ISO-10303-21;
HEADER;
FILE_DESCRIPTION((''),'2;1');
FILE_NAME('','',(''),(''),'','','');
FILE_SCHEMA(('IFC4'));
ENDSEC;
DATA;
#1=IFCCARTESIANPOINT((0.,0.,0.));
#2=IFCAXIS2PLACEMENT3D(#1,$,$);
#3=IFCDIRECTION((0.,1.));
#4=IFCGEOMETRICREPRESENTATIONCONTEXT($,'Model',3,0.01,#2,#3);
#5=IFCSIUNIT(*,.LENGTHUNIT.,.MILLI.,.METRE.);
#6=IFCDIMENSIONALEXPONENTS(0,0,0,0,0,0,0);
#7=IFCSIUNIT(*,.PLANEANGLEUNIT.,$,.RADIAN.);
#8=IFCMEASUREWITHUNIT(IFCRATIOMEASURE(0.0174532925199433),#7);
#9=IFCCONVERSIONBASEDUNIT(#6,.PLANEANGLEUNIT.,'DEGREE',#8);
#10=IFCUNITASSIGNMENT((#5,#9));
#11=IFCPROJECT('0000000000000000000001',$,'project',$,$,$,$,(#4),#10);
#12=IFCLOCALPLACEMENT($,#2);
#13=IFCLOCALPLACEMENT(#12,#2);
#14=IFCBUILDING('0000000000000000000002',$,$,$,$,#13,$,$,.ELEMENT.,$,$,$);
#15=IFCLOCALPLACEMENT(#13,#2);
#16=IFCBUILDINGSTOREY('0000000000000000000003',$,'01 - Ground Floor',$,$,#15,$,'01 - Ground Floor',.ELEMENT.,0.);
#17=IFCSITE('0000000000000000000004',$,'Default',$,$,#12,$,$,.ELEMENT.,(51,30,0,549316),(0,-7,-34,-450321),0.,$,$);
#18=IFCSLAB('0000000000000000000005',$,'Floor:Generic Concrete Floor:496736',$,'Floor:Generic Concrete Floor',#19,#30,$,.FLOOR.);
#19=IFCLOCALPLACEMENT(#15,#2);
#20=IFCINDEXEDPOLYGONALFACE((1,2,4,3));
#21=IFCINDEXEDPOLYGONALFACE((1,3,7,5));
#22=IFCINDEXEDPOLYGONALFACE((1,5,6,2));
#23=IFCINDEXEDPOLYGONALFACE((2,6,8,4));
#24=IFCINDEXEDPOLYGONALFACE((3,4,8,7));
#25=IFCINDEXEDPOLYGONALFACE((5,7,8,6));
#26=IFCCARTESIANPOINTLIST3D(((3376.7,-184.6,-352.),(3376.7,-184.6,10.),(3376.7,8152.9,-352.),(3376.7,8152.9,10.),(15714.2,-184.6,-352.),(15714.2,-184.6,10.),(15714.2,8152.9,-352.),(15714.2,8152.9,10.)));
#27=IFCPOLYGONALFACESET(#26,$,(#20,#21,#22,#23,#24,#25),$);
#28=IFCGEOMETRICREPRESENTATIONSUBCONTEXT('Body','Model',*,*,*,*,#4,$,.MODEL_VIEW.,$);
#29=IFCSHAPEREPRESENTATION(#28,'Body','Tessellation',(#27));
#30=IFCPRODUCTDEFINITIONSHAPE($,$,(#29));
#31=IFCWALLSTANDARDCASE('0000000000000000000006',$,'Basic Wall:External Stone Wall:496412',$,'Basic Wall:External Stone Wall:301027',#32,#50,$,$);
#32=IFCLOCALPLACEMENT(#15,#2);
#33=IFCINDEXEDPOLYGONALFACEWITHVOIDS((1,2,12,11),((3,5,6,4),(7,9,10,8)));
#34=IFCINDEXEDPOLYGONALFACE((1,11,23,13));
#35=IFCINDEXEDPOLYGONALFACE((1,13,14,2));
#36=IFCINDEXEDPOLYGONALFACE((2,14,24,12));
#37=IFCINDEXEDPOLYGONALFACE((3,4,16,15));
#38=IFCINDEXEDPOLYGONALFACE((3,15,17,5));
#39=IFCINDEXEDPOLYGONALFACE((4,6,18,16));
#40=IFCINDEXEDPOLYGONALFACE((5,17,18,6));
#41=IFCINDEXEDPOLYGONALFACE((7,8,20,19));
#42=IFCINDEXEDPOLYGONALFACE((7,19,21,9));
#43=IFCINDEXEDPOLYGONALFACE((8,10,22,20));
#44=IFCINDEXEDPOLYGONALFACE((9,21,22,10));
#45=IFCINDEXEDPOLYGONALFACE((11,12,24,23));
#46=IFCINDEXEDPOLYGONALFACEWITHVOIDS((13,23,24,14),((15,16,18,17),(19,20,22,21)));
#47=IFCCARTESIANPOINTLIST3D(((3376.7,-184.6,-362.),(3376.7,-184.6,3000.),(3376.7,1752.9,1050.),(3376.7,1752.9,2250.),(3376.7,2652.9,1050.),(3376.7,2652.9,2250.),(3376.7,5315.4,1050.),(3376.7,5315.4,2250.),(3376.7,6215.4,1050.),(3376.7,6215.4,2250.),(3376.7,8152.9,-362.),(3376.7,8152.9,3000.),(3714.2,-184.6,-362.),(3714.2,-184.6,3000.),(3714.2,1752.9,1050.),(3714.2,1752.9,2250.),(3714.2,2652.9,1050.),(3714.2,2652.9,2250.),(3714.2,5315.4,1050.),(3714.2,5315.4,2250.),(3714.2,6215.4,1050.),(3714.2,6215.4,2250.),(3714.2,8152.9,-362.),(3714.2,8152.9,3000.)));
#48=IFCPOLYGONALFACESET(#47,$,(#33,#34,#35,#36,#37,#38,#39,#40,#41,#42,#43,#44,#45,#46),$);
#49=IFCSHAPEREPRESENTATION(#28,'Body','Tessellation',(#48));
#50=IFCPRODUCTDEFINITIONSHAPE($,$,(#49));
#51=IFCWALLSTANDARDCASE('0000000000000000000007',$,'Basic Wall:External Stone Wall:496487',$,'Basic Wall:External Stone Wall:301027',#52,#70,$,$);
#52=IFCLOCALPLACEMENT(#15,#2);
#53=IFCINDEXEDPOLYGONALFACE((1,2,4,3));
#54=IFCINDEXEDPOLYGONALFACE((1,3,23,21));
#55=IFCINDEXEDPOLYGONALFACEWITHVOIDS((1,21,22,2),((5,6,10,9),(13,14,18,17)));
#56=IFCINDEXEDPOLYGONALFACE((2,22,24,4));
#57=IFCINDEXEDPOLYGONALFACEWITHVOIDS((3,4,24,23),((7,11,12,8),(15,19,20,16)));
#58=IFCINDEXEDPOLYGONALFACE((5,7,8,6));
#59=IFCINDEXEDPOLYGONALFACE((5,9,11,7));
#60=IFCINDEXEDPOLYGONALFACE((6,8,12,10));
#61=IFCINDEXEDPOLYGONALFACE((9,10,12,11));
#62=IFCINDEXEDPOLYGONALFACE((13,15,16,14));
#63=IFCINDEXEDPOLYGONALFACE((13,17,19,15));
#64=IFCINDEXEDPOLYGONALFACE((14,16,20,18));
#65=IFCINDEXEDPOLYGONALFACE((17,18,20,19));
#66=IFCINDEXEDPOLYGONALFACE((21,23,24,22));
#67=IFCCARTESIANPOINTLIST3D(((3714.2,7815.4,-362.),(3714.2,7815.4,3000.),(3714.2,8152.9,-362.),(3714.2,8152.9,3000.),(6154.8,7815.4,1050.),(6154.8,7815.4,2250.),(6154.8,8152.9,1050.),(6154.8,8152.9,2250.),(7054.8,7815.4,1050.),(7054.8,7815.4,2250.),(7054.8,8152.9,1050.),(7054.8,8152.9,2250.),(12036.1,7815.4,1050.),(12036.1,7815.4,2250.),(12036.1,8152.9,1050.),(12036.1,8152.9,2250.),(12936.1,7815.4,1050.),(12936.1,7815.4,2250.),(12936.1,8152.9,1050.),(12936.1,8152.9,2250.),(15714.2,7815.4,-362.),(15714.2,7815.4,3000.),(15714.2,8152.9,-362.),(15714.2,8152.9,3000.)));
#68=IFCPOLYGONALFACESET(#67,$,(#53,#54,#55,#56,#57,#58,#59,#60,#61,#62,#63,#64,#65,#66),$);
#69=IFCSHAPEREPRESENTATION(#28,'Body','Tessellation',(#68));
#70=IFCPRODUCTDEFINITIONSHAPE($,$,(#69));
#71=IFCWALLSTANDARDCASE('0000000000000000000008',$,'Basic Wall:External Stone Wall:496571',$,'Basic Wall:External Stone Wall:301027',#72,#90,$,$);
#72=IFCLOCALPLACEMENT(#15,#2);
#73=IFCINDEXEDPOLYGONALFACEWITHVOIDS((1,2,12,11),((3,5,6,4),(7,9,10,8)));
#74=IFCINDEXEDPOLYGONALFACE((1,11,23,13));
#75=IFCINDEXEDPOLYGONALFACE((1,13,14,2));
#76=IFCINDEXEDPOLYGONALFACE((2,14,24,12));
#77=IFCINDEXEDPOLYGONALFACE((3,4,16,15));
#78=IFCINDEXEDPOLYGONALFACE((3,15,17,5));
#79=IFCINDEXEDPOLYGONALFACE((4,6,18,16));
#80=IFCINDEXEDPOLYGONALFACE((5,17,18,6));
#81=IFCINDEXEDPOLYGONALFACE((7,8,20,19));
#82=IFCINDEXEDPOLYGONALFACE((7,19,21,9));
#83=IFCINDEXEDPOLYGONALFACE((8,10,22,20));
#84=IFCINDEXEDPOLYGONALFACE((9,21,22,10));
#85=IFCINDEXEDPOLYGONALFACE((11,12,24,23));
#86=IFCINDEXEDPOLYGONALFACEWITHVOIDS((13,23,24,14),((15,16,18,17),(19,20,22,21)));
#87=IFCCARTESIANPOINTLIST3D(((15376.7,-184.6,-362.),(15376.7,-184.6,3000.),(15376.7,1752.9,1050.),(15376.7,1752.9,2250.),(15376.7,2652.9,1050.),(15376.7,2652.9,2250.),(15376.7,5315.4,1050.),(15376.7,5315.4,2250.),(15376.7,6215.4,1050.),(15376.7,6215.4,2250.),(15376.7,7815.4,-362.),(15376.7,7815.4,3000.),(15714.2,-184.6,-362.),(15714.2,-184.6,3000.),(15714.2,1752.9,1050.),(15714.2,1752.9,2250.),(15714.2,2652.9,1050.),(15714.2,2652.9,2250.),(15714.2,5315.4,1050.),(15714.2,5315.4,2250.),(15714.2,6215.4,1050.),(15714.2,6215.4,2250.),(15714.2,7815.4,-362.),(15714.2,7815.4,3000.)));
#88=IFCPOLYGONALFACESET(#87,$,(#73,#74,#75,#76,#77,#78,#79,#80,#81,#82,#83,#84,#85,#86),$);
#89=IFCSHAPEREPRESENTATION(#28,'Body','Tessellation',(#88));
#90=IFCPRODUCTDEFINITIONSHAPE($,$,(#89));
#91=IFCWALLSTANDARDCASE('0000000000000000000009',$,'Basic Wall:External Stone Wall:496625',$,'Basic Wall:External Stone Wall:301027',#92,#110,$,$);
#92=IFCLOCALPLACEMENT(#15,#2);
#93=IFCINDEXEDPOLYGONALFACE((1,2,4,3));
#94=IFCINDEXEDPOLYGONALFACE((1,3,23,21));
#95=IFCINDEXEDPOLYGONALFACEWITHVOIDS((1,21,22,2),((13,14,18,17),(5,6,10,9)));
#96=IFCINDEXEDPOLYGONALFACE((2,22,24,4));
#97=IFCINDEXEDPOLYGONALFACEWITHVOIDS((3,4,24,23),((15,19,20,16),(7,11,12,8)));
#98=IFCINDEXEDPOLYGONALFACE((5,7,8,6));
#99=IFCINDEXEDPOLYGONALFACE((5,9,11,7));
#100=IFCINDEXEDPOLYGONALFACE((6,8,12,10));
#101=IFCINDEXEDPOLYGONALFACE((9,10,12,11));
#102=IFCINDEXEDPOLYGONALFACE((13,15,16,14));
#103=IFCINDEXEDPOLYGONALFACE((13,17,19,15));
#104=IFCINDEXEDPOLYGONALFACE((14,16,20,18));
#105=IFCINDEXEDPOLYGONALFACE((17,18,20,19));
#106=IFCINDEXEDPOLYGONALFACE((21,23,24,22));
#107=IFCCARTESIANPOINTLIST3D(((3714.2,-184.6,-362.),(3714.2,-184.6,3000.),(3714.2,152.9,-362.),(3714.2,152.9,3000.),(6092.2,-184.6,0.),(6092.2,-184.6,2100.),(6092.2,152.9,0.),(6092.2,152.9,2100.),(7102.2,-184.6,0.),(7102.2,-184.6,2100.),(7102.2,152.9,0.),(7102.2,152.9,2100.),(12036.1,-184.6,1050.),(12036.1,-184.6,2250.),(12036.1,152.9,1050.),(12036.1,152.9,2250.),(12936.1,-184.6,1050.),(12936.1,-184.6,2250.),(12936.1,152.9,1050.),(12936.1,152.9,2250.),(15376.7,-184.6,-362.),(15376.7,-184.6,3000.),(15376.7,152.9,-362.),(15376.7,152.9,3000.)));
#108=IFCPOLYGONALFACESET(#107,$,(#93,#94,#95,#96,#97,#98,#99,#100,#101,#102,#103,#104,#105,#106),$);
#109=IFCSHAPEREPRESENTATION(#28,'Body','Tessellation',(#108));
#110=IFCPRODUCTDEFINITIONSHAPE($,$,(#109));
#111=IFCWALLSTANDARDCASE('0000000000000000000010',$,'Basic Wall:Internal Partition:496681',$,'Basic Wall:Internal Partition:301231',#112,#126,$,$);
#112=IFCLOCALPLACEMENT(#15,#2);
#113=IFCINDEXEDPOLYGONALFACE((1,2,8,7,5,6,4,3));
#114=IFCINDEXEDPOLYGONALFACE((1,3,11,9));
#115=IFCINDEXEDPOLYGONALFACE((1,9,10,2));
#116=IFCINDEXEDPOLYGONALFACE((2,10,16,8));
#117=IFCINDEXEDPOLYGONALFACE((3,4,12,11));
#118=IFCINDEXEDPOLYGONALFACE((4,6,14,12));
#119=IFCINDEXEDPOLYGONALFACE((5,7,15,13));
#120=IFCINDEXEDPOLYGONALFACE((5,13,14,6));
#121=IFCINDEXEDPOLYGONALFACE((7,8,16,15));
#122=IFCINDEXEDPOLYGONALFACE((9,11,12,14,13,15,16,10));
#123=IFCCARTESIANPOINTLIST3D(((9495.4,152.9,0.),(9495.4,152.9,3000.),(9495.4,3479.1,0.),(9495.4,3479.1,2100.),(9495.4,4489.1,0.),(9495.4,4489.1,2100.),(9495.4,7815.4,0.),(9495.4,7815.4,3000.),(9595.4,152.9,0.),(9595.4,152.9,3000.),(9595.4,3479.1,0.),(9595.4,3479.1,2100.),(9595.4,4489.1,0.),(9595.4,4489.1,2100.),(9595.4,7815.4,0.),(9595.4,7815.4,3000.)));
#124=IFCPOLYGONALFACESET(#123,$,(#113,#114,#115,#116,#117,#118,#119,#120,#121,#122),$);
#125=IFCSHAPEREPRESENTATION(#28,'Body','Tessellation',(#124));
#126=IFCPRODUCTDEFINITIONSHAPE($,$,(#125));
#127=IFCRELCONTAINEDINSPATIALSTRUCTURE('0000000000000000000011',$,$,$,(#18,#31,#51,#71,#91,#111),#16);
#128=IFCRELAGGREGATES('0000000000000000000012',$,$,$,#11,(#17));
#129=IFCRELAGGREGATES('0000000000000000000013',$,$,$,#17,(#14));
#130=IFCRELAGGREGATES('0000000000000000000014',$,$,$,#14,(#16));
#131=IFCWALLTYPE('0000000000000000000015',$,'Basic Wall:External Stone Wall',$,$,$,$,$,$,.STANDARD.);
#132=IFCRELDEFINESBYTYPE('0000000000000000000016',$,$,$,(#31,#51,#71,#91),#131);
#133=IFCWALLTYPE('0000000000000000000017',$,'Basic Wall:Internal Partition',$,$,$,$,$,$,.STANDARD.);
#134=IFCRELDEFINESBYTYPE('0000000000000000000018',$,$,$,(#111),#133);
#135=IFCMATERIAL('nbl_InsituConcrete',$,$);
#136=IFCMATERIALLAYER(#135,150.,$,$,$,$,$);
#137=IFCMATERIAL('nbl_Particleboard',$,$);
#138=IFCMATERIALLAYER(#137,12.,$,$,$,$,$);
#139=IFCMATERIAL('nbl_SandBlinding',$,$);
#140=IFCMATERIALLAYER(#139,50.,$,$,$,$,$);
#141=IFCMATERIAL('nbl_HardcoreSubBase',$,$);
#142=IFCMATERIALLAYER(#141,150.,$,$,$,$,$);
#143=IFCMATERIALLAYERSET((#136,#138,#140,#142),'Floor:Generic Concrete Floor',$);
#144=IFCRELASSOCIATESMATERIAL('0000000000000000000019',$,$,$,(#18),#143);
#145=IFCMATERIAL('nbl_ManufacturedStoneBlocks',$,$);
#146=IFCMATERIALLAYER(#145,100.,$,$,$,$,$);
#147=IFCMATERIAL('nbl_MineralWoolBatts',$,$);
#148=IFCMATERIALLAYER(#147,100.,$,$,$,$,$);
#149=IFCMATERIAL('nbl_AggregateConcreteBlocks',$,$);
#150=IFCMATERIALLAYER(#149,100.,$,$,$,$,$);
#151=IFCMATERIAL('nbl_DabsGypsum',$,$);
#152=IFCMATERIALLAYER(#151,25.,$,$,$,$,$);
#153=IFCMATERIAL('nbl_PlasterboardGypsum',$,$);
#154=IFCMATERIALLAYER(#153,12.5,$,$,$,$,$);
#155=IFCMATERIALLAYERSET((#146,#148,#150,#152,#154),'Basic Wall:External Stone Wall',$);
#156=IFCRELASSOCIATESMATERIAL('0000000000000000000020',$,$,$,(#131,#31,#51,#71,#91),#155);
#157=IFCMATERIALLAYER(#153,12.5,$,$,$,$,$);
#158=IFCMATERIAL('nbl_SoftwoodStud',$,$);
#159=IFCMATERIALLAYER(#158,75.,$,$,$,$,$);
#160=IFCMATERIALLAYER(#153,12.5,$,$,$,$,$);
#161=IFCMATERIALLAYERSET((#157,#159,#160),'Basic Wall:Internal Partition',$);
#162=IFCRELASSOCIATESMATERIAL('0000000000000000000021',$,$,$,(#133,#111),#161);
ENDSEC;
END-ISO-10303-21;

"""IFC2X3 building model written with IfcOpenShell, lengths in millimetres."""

from ifc_helpers import new_model, entity, si_unit, converted_unit, direction, frame, frame_2d, origin, origin_2d_with_axis, place, context, subcontext, project, spatial, rectangle, extrude, material, layer, layer_set, layer_usage, type_object, element, save


model = new_model("IFC2X3")

# Units and contexts
model_context = context("Model", 3, precision=0.01, world=origin(), true_north=direction((0.0, 1.0)))
body_context = subcontext(model_context, "Body", "Model", "MODEL_VIEW")
ifc_project = project(units=[si_unit("LENGTHUNIT", "METRE", prefix="MILLI"), converted_unit("PLANEANGLEUNIT", "DEGREE", entity("IfcRatioMeasure", 0.0174532925199433), si_unit("PLANEANGLEUNIT", "RADIAN"), dimensions=[0, 0, 0, 0, 0, 0, 0])], contexts=[model_context])

# Site, building, storey
site_placement = place(None, origin())
site = spatial("IfcSite", under=ifc_project, at=site_placement, Name="Default", CompositionType="ELEMENT", RefLatitude=(51, 30, 0, 549316), RefLongitude=(0, -7, -34, -450321), RefElevation=0.0)
building_placement = place(site_placement, origin())
building = spatial("IfcBuilding", under=site, at=building_placement, CompositionType="ELEMENT")
storey_placement = place(building_placement, origin())
storey = spatial("IfcBuildingStorey", under=building, at=storey_placement, Name="01 - Ground Floor", LongName="01 - Ground Floor", CompositionType="ELEMENT", Elevation=0.0)

# Slab
ifc_material_1 = material(Name="nbl_InsituConcrete")
ifc_layer_1 = layer(ifc_material_1, 150.0)
ifc_material_2 = material(Name="nbl_Particleboard")
ifc_layer_2 = layer(ifc_material_2, 12.0)
ifc_material_3 = material(Name="nbl_SandBlinding")
ifc_layer_3 = layer(ifc_material_3, 50.0)
ifc_material_4 = material(Name="nbl_HardcoreSubBase")
ifc_layer_4 = layer(ifc_material_4, 150.0)
ifc_layer_set_1 = layer_set([ifc_layer_1, ifc_layer_2, ifc_layer_3, ifc_layer_4], Name="Floor:Generic Concrete Floor")
ifc_layer_usage_1 = layer_usage(ifc_layer_set_1, "AXIS3", "POSITIVE", 0.0)
slab_placement = place(storey_placement, origin())
element("IfcSlab", 1, at=slab_placement, inside=storey, material=ifc_layer_usage_1, Name="Floor:Generic Concrete Floor:496736", ObjectType="Floor:Generic Concrete Floor", PredefinedType="FLOOR", context=body_context, shape_type="SweptSolid", body=[
    extrude(rectangle(XDim=8337.5, YDim=12337.5, at=origin_2d_with_axis()), frame((9545.4, 3984.1, 10.0), z_axis=(0.0, 0.0, -1.0), x_axis=(0.0, 1.0, 0.0)), (0.0, 0.0, 1.0), 362.0),
])

# Walls, openings
ifc_material_5 = material(Name="nbl_ManufacturedStoneBlocks")
ifc_layer_5 = layer(ifc_material_5, 100.0)
ifc_material_6 = material(Name="nbl_MineralWoolBatts")
ifc_layer_6 = layer(ifc_material_6, 100.0)
ifc_material_7 = material(Name="nbl_AggregateConcreteBlocks")
ifc_layer_7 = layer(ifc_material_7, 100.0)
ifc_material_8 = material(Name="nbl_DabsGypsum")
ifc_layer_8 = layer(ifc_material_8, 25.0)
ifc_material_9 = material(Name="nbl_PlasterboardGypsum")
ifc_layer_9 = layer(ifc_material_9, 12.5)
ifc_layer_set_2 = layer_set([ifc_layer_5, ifc_layer_6, ifc_layer_7, ifc_layer_8, ifc_layer_9], Name="Basic Wall:External Stone Wall")
ifc_layer_usage_2 = layer_usage(ifc_layer_set_2, "AXIS2", "NEGATIVE", 168.8)
wall_type_1 = type_object("IfcWallType", Name="Basic Wall:External Stone Wall", PredefinedType="STANDARD", material=ifc_layer_set_2)
wall_1_placement = place(storey_placement, frame((3545.4, -184.6, -362.0), z_axis=(0.0, 0.0, 1.0), x_axis=(0.0, 1.0, 0.0)))
wall_1 = element("IfcWallStandardCase", 2, at=wall_1_placement, inside=storey, type_object=wall_type_1, material=ifc_layer_usage_2, Name="Basic Wall:External Stone Wall:496412", ObjectType="Basic Wall:External Stone Wall:301027", context=body_context, shape_type="SweptSolid", body=[
    extrude(rectangle(XDim=8337.5, YDim=337.5, at=frame_2d((4168.7, 0.0), x_axis=(-1.0, 0.0))), origin(), (0.0, 0.0, 1.0), 3362.0),
])
opening_1_placement = place(wall_1_placement, frame((5500.0, -168.8, 1412.0)))
element("IfcOpeningElement", 3, at=opening_1_placement, cuts=wall_1, ObjectType="Opening", context=body_context, shape_type="SweptSolid", body=[
    extrude(rectangle(XDim=1200.0, YDim=900.0, at=frame_2d((600.0, 450.0), x_axis=(-1.0, 0.0))), frame((0.0, 0.0, 0.0), z_axis=(0.0, 1.0, 0.0), x_axis=(0.0, 0.0, 1.0)), (0.0, 0.0, 1.0), 337.5),
])
opening_2_placement = place(wall_1_placement, frame((1937.5, -168.8, 1412.0)))
element("IfcOpeningElement", 4, at=opening_2_placement, cuts=wall_1, ObjectType="Opening", context=body_context, shape_type="SweptSolid", body=[
    extrude(rectangle(XDim=1200.0, YDim=900.0, at=frame_2d((600.0, 450.0), x_axis=(-1.0, 0.0))), frame((0.0, 0.0, 0.0), z_axis=(0.0, 1.0, 0.0), x_axis=(0.0, 0.0, 1.0)), (0.0, 0.0, 1.0), 337.5),
])
ifc_layer_usage_3 = layer_usage(ifc_layer_set_2, "AXIS2", "NEGATIVE", 168.8)
wall_2_placement = place(storey_placement, frame((3714.2, 7984.1, -362.0)))
wall_2 = element("IfcWallStandardCase", 5, at=wall_2_placement, inside=storey, type_object=wall_type_1, material=ifc_layer_usage_3, Name="Basic Wall:External Stone Wall:496487", ObjectType="Basic Wall:External Stone Wall:301027", context=body_context, shape_type="SweptSolid", body=[
    extrude(rectangle(XDim=12000.0, YDim=337.5, at=frame_2d((6000.0, 0.0), x_axis=(-1.0, 0.0))), origin(), (0.0, 0.0, 1.0), 3362.0),
])
opening_3_placement = place(wall_2_placement, frame((2440.6, -168.8, 1412.0)))
element("IfcOpeningElement", 6, at=opening_3_placement, cuts=wall_2, ObjectType="Opening", context=body_context, shape_type="SweptSolid", body=[
    extrude(rectangle(XDim=1200.0, YDim=900.0, at=frame_2d((600.0, 450.0), x_axis=(-1.0, 0.0))), frame((0.0, 0.0, 0.0), z_axis=(0.0, 1.0, 0.0), x_axis=(0.0, 0.0, 1.0)), (0.0, 0.0, 1.0), 337.5),
])
opening_4_placement = place(wall_2_placement, frame((8321.9, -168.8, 1412.0)))
element("IfcOpeningElement", 7, at=opening_4_placement, cuts=wall_2, ObjectType="Opening", context=body_context, shape_type="SweptSolid", body=[
    extrude(rectangle(XDim=1200.0, YDim=900.0, at=frame_2d((600.0, 450.0), x_axis=(-1.0, 0.0))), frame((0.0, 0.0, 0.0), z_axis=(0.0, 1.0, 0.0), x_axis=(0.0, 0.0, 1.0)), (0.0, 0.0, 1.0), 337.5),
])
ifc_layer_usage_4 = layer_usage(ifc_layer_set_2, "AXIS2", "NEGATIVE", 168.8)
wall_3_placement = place(storey_placement, frame((15545.4, 7815.4, -362.0), z_axis=(0.0, 0.0, 1.0), x_axis=(0.0, -1.0, 0.0)))
wall_3 = element("IfcWallStandardCase", 8, at=wall_3_placement, inside=storey, type_object=wall_type_1, material=ifc_layer_usage_4, Name="Basic Wall:External Stone Wall:496571", ObjectType="Basic Wall:External Stone Wall:301027", context=body_context, shape_type="SweptSolid", body=[
    extrude(rectangle(XDim=8000.0, YDim=337.5, at=frame_2d((4000.0, 0.0), x_axis=(-1.0, 0.0))), origin(), (0.0, 0.0, 1.0), 3362.0),
])
opening_5_placement = place(wall_3_placement, frame((1600.0, -168.8, 1412.0)))
element("IfcOpeningElement", 9, at=opening_5_placement, cuts=wall_3, ObjectType="Opening", context=body_context, shape_type="SweptSolid", body=[
    extrude(rectangle(XDim=1200.0, YDim=900.0, at=frame_2d((600.0, 450.0), x_axis=(-1.0, 0.0))), frame((0.0, 0.0, 0.0), z_axis=(0.0, 1.0, 0.0), x_axis=(0.0, 0.0, 1.0)), (0.0, 0.0, 1.0), 337.5),
])
opening_6_placement = place(wall_3_placement, frame((5162.5, -168.8, 1412.0)))
element("IfcOpeningElement", 10, at=opening_6_placement, cuts=wall_3, ObjectType="Opening", context=body_context, shape_type="SweptSolid", body=[
    extrude(rectangle(XDim=1200.0, YDim=900.0, at=frame_2d((600.0, 450.0), x_axis=(-1.0, 0.0))), frame((0.0, 0.0, 0.0), z_axis=(0.0, 1.0, 0.0), x_axis=(0.0, 0.0, 1.0)), (0.0, 0.0, 1.0), 337.5),
])
ifc_layer_usage_5 = layer_usage(ifc_layer_set_2, "AXIS2", "NEGATIVE", 168.8)
wall_4_placement = place(storey_placement, frame((15376.7, -15.9, -362.0), z_axis=(0.0, 0.0, 1.0), x_axis=(-1.0, 0.0, 0.0)))
wall_4 = element("IfcWallStandardCase", 11, at=wall_4_placement, inside=storey, type_object=wall_type_1, material=ifc_layer_usage_5, Name="Basic Wall:External Stone Wall:496625", ObjectType="Basic Wall:External Stone Wall:301027", context=body_context, shape_type="SweptSolid", body=[
    extrude(rectangle(XDim=11662.5, YDim=337.5, at=frame_2d((5831.2, 0.0), x_axis=(-1.0, 0.0))), origin(), (0.0, 0.0, 1.0), 3362.0),
])
opening_7_placement = place(wall_4_placement, frame((9284.5, 168.7, 362.0)))
element("IfcOpeningElement", 12, at=opening_7_placement, cuts=wall_4, ObjectType="Opening", context=body_context, shape_type="SweptSolid", body=[
    extrude(rectangle(XDim=2100.0, YDim=1010.0, at=frame_2d((1050.0, 505.0), x_axis=(-1.0, 0.0))), frame((0.0, 0.0, 0.0), z_axis=(0.0, -1.0, 0.0), x_axis=(0.0, 0.0, 1.0)), (0.0, 0.0, 1.0), 337.5),
])
opening_8_placement = place(wall_4_placement, frame((2440.6, -168.8, 1412.0)))
element("IfcOpeningElement", 13, at=opening_8_placement, cuts=wall_4, ObjectType="Opening", context=body_context, shape_type="SweptSolid", body=[
    extrude(rectangle(XDim=1200.0, YDim=900.0, at=frame_2d((600.0, 450.0), x_axis=(-1.0, 0.0))), frame((0.0, 0.0, 0.0), z_axis=(0.0, 1.0, 0.0), x_axis=(0.0, 0.0, 1.0)), (0.0, 0.0, 1.0), 337.5),
])

# Wall, opening
ifc_layer_10 = layer(ifc_material_9, 12.5)
ifc_material_10 = material(Name="nbl_SoftwoodStud")
ifc_layer_11 = layer(ifc_material_10, 75.0)
ifc_layer_12 = layer(ifc_material_9, 12.5)
ifc_layer_set_3 = layer_set([ifc_layer_10, ifc_layer_11, ifc_layer_12], Name="Basic Wall:Internal Partition")
ifc_layer_usage_6 = layer_usage(ifc_layer_set_3, "AXIS2", "NEGATIVE", 50.0)
wall_type_2 = type_object("IfcWallType", Name="Basic Wall:Internal Partition", PredefinedType="STANDARD", material=ifc_layer_set_3)
wall_5_placement = place(storey_placement, frame((9545.4, 7815.4, 0.0), z_axis=(0.0, 0.0, 1.0), x_axis=(0.0, -1.0, 0.0)))
wall_5 = element("IfcWallStandardCase", 14, at=wall_5_placement, inside=storey, type_object=wall_type_2, material=ifc_layer_usage_6, Name="Basic Wall:Internal Partition:496681", ObjectType="Basic Wall:Internal Partition:301231", context=body_context, shape_type="SweptSolid", body=[
    extrude(rectangle(XDim=7662.5, YDim=100.0, at=frame_2d((3831.2, 0.0), x_axis=(-1.0, 0.0))), origin(), (0.0, 0.0, 1.0), 3000.0),
])
opening_9_placement = place(wall_5_placement, frame((3326.2, -50.0, 0.0)))
element("IfcOpeningElement", 15, at=opening_9_placement, cuts=wall_5, ObjectType="Opening", context=body_context, shape_type="SweptSolid", body=[
    extrude(rectangle(XDim=2100.0, YDim=1010.0, at=frame_2d((1050.0, 505.0), x_axis=(-1.0, 0.0))), frame((0.0, 0.0, 0.0), z_axis=(0.0, 1.0, 0.0), x_axis=(0.0, 0.0, 1.0)), (0.0, 0.0, 1.0), 100.0),
])

save(model, "model.ifc")
